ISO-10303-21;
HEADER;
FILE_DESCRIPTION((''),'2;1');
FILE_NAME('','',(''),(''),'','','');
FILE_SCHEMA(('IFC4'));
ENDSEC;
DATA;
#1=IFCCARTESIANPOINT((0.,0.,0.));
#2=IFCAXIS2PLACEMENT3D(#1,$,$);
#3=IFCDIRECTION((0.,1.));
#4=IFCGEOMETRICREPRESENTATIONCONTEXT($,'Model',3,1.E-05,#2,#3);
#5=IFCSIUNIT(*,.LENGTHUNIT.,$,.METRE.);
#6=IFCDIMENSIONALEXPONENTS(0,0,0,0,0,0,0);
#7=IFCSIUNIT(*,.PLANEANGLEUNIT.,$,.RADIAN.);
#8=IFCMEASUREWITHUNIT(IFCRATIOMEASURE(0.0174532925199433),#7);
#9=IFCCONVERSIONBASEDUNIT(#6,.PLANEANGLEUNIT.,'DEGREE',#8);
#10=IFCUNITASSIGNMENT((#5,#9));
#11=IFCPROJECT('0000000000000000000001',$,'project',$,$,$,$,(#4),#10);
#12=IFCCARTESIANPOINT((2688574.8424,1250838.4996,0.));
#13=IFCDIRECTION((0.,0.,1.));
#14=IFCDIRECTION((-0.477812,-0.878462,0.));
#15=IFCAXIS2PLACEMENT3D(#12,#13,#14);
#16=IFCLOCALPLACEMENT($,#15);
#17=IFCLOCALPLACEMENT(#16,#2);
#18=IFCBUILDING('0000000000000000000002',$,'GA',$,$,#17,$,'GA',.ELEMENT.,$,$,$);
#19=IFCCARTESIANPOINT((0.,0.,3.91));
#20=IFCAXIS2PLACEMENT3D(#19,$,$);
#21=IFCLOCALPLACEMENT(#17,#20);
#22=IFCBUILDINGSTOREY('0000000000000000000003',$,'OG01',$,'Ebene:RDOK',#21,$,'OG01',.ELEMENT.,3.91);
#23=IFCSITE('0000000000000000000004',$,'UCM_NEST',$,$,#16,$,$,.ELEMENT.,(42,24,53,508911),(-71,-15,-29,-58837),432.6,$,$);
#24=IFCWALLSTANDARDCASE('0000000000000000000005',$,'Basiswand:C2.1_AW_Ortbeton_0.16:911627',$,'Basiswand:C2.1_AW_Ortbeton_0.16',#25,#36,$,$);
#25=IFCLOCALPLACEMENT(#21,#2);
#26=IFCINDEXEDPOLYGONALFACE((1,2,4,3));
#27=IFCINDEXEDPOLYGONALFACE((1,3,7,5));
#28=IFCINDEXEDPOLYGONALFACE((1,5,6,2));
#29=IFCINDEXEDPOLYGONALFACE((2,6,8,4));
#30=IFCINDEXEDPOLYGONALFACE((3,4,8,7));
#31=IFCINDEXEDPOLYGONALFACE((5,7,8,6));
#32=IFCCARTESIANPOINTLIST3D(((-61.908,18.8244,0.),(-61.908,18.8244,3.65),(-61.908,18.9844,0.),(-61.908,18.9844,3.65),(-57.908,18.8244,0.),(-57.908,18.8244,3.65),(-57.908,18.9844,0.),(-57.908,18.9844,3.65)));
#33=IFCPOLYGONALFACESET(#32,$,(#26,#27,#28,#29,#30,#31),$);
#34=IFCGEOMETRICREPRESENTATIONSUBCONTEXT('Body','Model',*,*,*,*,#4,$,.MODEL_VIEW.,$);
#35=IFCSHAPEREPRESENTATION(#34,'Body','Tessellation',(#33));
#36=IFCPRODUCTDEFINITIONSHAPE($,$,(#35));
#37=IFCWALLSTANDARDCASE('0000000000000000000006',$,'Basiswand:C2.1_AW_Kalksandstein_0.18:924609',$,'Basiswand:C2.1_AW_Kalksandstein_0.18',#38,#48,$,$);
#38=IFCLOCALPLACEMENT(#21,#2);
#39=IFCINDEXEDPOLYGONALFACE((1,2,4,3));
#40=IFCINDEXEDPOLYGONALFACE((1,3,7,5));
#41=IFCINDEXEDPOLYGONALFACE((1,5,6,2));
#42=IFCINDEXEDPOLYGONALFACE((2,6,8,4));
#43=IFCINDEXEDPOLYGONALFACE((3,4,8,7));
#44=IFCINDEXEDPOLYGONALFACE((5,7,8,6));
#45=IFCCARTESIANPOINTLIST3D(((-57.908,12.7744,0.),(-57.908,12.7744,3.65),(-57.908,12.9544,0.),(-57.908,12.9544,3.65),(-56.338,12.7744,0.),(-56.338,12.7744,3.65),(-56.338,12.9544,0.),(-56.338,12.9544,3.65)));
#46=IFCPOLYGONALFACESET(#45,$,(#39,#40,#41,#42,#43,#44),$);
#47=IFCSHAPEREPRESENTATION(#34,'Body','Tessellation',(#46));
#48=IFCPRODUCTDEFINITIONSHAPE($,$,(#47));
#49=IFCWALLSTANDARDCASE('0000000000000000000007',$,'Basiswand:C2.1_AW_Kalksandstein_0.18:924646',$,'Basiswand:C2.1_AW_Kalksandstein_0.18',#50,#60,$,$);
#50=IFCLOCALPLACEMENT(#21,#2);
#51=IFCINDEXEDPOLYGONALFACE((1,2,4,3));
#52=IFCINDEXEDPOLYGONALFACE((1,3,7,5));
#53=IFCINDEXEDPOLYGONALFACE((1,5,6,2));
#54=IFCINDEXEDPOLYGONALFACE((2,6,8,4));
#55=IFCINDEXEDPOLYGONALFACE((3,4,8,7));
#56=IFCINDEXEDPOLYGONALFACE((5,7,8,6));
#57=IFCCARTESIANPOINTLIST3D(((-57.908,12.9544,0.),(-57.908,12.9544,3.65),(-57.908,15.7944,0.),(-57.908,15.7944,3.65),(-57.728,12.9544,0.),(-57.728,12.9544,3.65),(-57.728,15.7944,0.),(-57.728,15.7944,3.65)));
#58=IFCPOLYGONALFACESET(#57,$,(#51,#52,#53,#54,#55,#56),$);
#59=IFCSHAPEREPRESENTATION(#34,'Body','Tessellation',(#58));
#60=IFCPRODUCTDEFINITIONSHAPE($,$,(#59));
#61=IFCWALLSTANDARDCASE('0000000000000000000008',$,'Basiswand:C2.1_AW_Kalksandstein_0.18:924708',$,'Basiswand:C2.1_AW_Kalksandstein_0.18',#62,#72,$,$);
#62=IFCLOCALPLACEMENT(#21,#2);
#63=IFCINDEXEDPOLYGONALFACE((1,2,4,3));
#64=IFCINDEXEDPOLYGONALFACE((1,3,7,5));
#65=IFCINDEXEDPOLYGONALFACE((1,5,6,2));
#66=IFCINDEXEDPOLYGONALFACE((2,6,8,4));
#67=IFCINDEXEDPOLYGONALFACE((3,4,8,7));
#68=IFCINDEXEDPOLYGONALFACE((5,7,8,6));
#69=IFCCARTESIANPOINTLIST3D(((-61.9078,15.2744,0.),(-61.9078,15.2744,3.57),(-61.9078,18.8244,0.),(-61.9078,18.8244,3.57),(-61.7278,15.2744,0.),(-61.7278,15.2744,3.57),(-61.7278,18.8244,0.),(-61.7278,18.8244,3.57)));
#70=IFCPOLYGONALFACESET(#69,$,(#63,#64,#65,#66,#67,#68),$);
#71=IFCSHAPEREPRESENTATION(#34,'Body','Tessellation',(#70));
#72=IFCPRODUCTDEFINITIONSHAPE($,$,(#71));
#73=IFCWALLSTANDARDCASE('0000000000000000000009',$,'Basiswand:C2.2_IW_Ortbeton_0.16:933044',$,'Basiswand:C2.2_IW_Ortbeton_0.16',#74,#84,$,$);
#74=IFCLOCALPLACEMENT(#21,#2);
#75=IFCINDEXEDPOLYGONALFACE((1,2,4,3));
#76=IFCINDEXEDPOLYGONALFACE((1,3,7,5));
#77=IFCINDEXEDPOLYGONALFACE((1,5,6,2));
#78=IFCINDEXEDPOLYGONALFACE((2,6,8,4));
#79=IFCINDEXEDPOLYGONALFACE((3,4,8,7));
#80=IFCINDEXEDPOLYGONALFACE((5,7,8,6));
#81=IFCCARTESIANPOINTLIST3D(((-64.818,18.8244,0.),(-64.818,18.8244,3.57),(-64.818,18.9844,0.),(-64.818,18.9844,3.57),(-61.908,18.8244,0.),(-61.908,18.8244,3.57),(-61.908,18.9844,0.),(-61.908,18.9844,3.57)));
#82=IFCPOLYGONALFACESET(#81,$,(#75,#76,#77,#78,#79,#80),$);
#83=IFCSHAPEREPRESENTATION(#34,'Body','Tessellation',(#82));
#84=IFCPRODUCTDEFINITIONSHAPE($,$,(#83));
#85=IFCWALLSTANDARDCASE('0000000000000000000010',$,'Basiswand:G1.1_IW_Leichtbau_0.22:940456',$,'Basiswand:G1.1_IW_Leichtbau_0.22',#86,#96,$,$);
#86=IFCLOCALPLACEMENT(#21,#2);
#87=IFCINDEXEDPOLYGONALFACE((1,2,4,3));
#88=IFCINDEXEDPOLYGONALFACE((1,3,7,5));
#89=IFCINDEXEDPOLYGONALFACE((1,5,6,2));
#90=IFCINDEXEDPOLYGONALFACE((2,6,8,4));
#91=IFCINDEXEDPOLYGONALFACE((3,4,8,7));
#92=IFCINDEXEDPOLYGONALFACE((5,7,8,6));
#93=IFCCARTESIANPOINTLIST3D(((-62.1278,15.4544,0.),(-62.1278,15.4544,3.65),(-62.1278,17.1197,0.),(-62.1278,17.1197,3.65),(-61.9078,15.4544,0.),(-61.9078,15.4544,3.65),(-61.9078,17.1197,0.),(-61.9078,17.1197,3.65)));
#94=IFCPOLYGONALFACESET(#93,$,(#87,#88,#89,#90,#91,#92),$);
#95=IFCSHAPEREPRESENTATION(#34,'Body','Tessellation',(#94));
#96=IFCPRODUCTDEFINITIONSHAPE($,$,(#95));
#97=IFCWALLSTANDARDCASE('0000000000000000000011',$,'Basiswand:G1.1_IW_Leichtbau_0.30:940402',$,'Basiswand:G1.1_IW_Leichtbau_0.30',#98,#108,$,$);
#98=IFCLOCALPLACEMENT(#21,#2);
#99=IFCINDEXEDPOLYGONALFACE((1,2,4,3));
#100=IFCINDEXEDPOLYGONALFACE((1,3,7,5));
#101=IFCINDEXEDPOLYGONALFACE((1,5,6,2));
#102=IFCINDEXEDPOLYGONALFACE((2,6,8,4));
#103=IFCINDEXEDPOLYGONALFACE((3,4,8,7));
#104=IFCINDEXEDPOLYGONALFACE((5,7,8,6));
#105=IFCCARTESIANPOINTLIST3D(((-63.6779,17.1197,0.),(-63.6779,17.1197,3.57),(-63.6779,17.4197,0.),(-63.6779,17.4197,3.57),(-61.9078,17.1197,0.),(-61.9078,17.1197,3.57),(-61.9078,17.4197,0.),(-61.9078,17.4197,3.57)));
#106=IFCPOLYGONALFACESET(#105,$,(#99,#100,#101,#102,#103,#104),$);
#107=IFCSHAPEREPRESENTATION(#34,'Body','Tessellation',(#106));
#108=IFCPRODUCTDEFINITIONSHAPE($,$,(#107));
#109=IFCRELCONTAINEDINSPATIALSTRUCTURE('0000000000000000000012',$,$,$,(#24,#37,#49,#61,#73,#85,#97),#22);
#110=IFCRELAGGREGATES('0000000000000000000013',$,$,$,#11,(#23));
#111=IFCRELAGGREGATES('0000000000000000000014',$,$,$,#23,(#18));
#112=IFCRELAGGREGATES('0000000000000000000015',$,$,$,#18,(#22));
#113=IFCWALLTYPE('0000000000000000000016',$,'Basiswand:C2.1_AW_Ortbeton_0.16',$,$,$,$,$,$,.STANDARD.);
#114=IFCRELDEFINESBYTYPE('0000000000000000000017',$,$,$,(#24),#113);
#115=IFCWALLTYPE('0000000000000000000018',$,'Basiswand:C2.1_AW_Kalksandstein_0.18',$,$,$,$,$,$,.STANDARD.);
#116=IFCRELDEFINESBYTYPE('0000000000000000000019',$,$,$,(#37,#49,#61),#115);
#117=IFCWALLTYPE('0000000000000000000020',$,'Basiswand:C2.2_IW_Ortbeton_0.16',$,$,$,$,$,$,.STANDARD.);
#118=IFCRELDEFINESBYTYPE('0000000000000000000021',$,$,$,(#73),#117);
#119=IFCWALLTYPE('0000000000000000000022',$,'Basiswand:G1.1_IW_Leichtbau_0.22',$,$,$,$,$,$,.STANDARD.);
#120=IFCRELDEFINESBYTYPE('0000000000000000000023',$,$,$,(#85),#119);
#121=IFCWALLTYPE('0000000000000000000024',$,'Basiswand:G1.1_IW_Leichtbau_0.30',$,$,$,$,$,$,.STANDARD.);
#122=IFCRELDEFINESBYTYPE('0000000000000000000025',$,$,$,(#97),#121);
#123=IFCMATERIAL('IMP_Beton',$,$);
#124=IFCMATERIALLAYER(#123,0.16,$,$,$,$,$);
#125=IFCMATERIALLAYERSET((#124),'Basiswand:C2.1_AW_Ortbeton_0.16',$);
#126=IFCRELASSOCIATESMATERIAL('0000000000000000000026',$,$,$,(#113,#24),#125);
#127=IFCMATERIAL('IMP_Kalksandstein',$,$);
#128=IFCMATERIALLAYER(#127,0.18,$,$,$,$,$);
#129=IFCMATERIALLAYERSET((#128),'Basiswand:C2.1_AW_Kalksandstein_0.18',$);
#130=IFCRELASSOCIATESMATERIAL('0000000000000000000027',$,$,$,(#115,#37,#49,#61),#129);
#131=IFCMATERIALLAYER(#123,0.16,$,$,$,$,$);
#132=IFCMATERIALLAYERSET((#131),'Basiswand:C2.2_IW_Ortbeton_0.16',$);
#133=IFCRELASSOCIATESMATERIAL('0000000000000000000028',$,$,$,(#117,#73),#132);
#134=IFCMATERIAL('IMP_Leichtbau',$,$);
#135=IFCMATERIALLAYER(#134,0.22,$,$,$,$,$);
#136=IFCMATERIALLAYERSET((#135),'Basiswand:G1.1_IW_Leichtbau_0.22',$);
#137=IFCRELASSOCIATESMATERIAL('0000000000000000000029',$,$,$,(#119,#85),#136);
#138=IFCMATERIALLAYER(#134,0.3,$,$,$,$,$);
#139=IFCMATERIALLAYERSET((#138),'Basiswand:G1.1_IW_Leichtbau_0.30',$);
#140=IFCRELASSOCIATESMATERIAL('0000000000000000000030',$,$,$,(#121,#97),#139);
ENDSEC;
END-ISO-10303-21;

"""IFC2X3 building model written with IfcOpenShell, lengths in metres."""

from ifc_helpers import new_model, entity, si_unit, converted_unit, direction, frame, frame_2d, origin, place, context, subcontext, project, spatial, polyline, rectangle, extrude, clip, bounded_halfspace, material, layer, layer_set, layer_usage, type_object, element, save


model = new_model("IFC2X3")

# Units and contexts
model_context = context("Model", 3, precision=1e-05, world=origin(), true_north=direction((0.0, 1.0)))
body_context = subcontext(model_context, "Body", "Model", "MODEL_VIEW")
ifc_project = project(units=[si_unit("LENGTHUNIT", "METRE"), converted_unit("PLANEANGLEUNIT", "DEGREE", entity("IfcRatioMeasure", 0.0174532925199433), si_unit("PLANEANGLEUNIT", "RADIAN"), dimensions=[0, 0, 0, 0, 0, 0, 0])], contexts=[model_context])

# Site, building, storey
site_placement = place(None, frame((2688574.8424, 1250838.4996, 0.0), z_axis=(0.0, 0.0, 1.0), x_axis=(-0.477812, -0.878462, 0.0)))
site = spatial("IfcSite", under=ifc_project, at=site_placement, Name="UCM_NEST", CompositionType="ELEMENT", RefLatitude=(42, 24, 53, 508911), RefLongitude=(-71, -15, -29, -58837), RefElevation=432.6)
building_placement = place(site_placement, origin())
building = spatial("IfcBuilding", under=site, at=building_placement, Name="GA", LongName="GA", CompositionType="ELEMENT")
storey_placement = place(building_placement, frame((0.0, 0.0, 3.91)))
storey = spatial("IfcBuildingStorey", under=building, at=storey_placement, Name="OG01", ObjectType="Ebene:RDOK", LongName="OG01", CompositionType="ELEMENT", Elevation=3.91)

# Shared definitions
ifc_material_1 = material(Name="IMP_Beton")
ifc_layer_1 = layer(ifc_material_1, 0.16)
ifc_layer_set_1 = layer_set([ifc_layer_1], Name="Basiswand:C2.1_AW_Ortbeton_0.16")
wall_type_1 = type_object("IfcWallType", Name="Basiswand:C2.1_AW_Ortbeton_0.16", PredefinedType="STANDARD", material=ifc_layer_set_1)

# Walls
ifc_layer_usage_1 = layer_usage(ifc_layer_set_1, "AXIS2", "NEGATIVE", 0.08)
wall_1_placement = place(storey_placement, frame((-57.908, 18.9044, 0.0), z_axis=(0.0, 0.0, 1.0), x_axis=(-1.0, 0.0, 0.0)))
element("IfcWallStandardCase", 1, at=wall_1_placement, inside=storey, type_object=wall_type_1, material=ifc_layer_usage_1, Name="Basiswand:C2.1_AW_Ortbeton_0.16:911627", ObjectType="Basiswand:C2.1_AW_Ortbeton_0.16", context=body_context, shape_type="SweptSolid", body=[
    extrude(rectangle(XDim=4.0, YDim=0.16, at=frame_2d((2.0, 0.0), x_axis=(-1.0, 0.0))), origin(), (0.0, 0.0, 1.0), 3.65),
])
ifc_material_2 = material(Name="IMP_Kalksandstein")
ifc_layer_2 = layer(ifc_material_2, 0.18)
ifc_layer_set_2 = layer_set([ifc_layer_2], Name="Basiswand:C2.1_AW_Kalksandstein_0.18")
ifc_layer_usage_2 = layer_usage(ifc_layer_set_2, "AXIS2", "NEGATIVE", 0.09)
wall_type_2 = type_object("IfcWallType", Name="Basiswand:C2.1_AW_Kalksandstein_0.18", PredefinedType="STANDARD", material=ifc_layer_set_2)
wall_2_placement = place(storey_placement, frame((-56.338, 12.8644, 0.0), z_axis=(0.0, 0.0, 1.0), x_axis=(-1.0, 0.0, 0.0)))
element("IfcWallStandardCase", 2, at=wall_2_placement, inside=storey, type_object=wall_type_2, material=ifc_layer_usage_2, Name="Basiswand:C2.1_AW_Kalksandstein_0.18:924609", ObjectType="Basiswand:C2.1_AW_Kalksandstein_0.18", context=body_context, shape_type="SweptSolid", body=[
    extrude(rectangle(XDim=1.57, YDim=0.18, at=frame_2d((0.785, 0.0), x_axis=(-1.0, 0.0))), origin(), (0.0, 0.0, 1.0), 3.65),
])
ifc_layer_usage_3 = layer_usage(ifc_layer_set_2, "AXIS2", "NEGATIVE", 0.09)
wall_3_placement = place(storey_placement, frame((-57.818, 12.9544, 0.0), z_axis=(0.0, 0.0, 1.0), x_axis=(0.0, 1.0, 0.0)))
element("IfcWallStandardCase", 3, at=wall_3_placement, inside=storey, type_object=wall_type_2, material=ifc_layer_usage_3, Name="Basiswand:C2.1_AW_Kalksandstein_0.18:924646", ObjectType="Basiswand:C2.1_AW_Kalksandstein_0.18", context=body_context, shape_type="SweptSolid", body=[
    extrude(rectangle(XDim=2.84, YDim=0.18, at=frame_2d((1.42, 0.0), x_axis=(-1.0, 0.0))), origin(), (0.0, 0.0, 1.0), 3.65),
])
ifc_layer_usage_4 = layer_usage(ifc_layer_set_2, "AXIS2", "NEGATIVE", 0.09)
wall_4_placement = place(storey_placement, frame((-61.8178, 18.8244, 0.0), z_axis=(0.0, 0.0, 1.0), x_axis=(0.0, -1.0, 0.0)))
element("IfcWallStandardCase", 4, at=wall_4_placement, inside=storey, type_object=wall_type_2, material=ifc_layer_usage_4, Name="Basiswand:C2.1_AW_Kalksandstein_0.18:924708", ObjectType="Basiswand:C2.1_AW_Kalksandstein_0.18", context=body_context, shape_type="Clipping", body=[
    clip(extrude(rectangle(XDim=3.55, YDim=0.18, at=frame_2d((1.775, 0.0), x_axis=(-1.0, 0.0))), origin(), (0.0, 0.0, 1.0), 3.57), bounded_halfspace(frame((0.0, -0.09, 3.57), z_axis=(0.0, 0.0, -1.0), x_axis=(1.0, 0.0, 0.0)), True, frame((0.0, -0.09, 3.57), z_axis=(0.0, 0.0, -1.0), x_axis=(1.0, 0.0, 0.0)), polyline([(0.0, 0.0), (0.0, -0.18), (3.55, -0.18), (3.55, 0.0), (3.37, 0.0), (1.7048, 0.0), (1.4048, 0.0), (0.0, 0.0)]))),
])

# Wall
ifc_layer_3 = layer(ifc_material_1, 0.16)
ifc_layer_set_3 = layer_set([ifc_layer_3], Name="Basiswand:C2.2_IW_Ortbeton_0.16")
ifc_layer_usage_5 = layer_usage(ifc_layer_set_3, "AXIS2", "NEGATIVE", 0.08)
wall_type_3 = type_object("IfcWallType", Name="Basiswand:C2.2_IW_Ortbeton_0.16", PredefinedType="STANDARD", material=ifc_layer_set_3)
wall_5_placement = place(storey_placement, frame((-61.908, 18.9044, 0.0), z_axis=(0.0, 0.0, 1.0), x_axis=(-1.0, 0.0, 0.0)))
element("IfcWallStandardCase", 5, at=wall_5_placement, inside=storey, type_object=wall_type_3, material=ifc_layer_usage_5, Name="Basiswand:C2.2_IW_Ortbeton_0.16:933044", ObjectType="Basiswand:C2.2_IW_Ortbeton_0.16", context=body_context, shape_type="Clipping", body=[
    clip(extrude(rectangle(XDim=2.91, YDim=0.16, at=frame_2d((1.455, 0.0), x_axis=(-1.0, 0.0))), origin(), (0.0, 0.0, 1.0), 3.57), bounded_halfspace(frame((0.0, -0.08, 3.57), z_axis=(0.0, 0.0, -1.0), x_axis=(0.0, 1.0, 0.0)), True, frame((0.0, -0.08, 3.57), z_axis=(0.0, 0.0, -1.0), x_axis=(0.0, 1.0, 0.0)), polyline([(0.0, 0.0), (0.16, 0.0), (0.16, 2.91), (0.0, 2.91), (0.0, 0.0)]))),
])

# Wall
ifc_material_3 = material(Name="IMP_Leichtbau")
ifc_layer_4 = layer(ifc_material_3, 0.22)
ifc_layer_set_4 = layer_set([ifc_layer_4], Name="Basiswand:G1.1_IW_Leichtbau_0.22")
ifc_layer_usage_6 = layer_usage(ifc_layer_set_4, "AXIS2", "NEGATIVE", 0.11)
wall_type_4 = type_object("IfcWallType", Name="Basiswand:G1.1_IW_Leichtbau_0.22", PredefinedType="STANDARD", material=ifc_layer_set_4)
wall_6_placement = place(storey_placement, frame((-62.0178, 15.4544, 0.0), z_axis=(0.0, 0.0, 1.0), x_axis=(0.0, 1.0, 0.0)))
element("IfcWallStandardCase", 6, at=wall_6_placement, inside=storey, type_object=wall_type_4, material=ifc_layer_usage_6, Name="Basiswand:G1.1_IW_Leichtbau_0.22:940456", ObjectType="Basiswand:G1.1_IW_Leichtbau_0.22", context=body_context, shape_type="SweptSolid", body=[
    extrude(rectangle(XDim=1.6652, YDim=0.22, at=frame_2d((0.8326, 0.0), x_axis=(-1.0, 0.0))), origin(), (0.0, 0.0, 1.0), 3.65),
])

# Wall
ifc_layer_5 = layer(ifc_material_3, 0.3)
ifc_layer_set_5 = layer_set([ifc_layer_5], Name="Basiswand:G1.1_IW_Leichtbau_0.30")
ifc_layer_usage_7 = layer_usage(ifc_layer_set_5, "AXIS2", "NEGATIVE", 0.15)
wall_type_5 = type_object("IfcWallType", Name="Basiswand:G1.1_IW_Leichtbau_0.30", PredefinedType="STANDARD", material=ifc_layer_set_5)
wall_7_placement = place(storey_placement, frame((-63.6779, 17.2697, 0.0)))
element("IfcWallStandardCase", 7, at=wall_7_placement, inside=storey, type_object=wall_type_5, material=ifc_layer_usage_7, Name="Basiswand:G1.1_IW_Leichtbau_0.30:940402", ObjectType="Basiswand:G1.1_IW_Leichtbau_0.30", context=body_context, shape_type="Clipping", body=[
    clip(extrude(rectangle(XDim=1.7702, YDim=0.3, at=frame_2d((0.8851, 0.0), x_axis=(-1.0, 0.0))), origin(), (0.0, 0.0, 1.0), 3.57), bounded_halfspace(frame((0.0, -0.15, 3.57), z_axis=(0.0, 0.0, -1.0), x_axis=(0.0, -1.0, 0.0)), True, frame((0.0, -0.15, 3.57), z_axis=(0.0, 0.0, -1.0), x_axis=(0.0, -1.0, 0.0)), polyline([(0.0, 0.0), (-0.3, 0.0), (-0.3, -1.7702), (0.0, -1.7702), (0.0, 0.0)]))),
])

save(model, "model.ifc")
